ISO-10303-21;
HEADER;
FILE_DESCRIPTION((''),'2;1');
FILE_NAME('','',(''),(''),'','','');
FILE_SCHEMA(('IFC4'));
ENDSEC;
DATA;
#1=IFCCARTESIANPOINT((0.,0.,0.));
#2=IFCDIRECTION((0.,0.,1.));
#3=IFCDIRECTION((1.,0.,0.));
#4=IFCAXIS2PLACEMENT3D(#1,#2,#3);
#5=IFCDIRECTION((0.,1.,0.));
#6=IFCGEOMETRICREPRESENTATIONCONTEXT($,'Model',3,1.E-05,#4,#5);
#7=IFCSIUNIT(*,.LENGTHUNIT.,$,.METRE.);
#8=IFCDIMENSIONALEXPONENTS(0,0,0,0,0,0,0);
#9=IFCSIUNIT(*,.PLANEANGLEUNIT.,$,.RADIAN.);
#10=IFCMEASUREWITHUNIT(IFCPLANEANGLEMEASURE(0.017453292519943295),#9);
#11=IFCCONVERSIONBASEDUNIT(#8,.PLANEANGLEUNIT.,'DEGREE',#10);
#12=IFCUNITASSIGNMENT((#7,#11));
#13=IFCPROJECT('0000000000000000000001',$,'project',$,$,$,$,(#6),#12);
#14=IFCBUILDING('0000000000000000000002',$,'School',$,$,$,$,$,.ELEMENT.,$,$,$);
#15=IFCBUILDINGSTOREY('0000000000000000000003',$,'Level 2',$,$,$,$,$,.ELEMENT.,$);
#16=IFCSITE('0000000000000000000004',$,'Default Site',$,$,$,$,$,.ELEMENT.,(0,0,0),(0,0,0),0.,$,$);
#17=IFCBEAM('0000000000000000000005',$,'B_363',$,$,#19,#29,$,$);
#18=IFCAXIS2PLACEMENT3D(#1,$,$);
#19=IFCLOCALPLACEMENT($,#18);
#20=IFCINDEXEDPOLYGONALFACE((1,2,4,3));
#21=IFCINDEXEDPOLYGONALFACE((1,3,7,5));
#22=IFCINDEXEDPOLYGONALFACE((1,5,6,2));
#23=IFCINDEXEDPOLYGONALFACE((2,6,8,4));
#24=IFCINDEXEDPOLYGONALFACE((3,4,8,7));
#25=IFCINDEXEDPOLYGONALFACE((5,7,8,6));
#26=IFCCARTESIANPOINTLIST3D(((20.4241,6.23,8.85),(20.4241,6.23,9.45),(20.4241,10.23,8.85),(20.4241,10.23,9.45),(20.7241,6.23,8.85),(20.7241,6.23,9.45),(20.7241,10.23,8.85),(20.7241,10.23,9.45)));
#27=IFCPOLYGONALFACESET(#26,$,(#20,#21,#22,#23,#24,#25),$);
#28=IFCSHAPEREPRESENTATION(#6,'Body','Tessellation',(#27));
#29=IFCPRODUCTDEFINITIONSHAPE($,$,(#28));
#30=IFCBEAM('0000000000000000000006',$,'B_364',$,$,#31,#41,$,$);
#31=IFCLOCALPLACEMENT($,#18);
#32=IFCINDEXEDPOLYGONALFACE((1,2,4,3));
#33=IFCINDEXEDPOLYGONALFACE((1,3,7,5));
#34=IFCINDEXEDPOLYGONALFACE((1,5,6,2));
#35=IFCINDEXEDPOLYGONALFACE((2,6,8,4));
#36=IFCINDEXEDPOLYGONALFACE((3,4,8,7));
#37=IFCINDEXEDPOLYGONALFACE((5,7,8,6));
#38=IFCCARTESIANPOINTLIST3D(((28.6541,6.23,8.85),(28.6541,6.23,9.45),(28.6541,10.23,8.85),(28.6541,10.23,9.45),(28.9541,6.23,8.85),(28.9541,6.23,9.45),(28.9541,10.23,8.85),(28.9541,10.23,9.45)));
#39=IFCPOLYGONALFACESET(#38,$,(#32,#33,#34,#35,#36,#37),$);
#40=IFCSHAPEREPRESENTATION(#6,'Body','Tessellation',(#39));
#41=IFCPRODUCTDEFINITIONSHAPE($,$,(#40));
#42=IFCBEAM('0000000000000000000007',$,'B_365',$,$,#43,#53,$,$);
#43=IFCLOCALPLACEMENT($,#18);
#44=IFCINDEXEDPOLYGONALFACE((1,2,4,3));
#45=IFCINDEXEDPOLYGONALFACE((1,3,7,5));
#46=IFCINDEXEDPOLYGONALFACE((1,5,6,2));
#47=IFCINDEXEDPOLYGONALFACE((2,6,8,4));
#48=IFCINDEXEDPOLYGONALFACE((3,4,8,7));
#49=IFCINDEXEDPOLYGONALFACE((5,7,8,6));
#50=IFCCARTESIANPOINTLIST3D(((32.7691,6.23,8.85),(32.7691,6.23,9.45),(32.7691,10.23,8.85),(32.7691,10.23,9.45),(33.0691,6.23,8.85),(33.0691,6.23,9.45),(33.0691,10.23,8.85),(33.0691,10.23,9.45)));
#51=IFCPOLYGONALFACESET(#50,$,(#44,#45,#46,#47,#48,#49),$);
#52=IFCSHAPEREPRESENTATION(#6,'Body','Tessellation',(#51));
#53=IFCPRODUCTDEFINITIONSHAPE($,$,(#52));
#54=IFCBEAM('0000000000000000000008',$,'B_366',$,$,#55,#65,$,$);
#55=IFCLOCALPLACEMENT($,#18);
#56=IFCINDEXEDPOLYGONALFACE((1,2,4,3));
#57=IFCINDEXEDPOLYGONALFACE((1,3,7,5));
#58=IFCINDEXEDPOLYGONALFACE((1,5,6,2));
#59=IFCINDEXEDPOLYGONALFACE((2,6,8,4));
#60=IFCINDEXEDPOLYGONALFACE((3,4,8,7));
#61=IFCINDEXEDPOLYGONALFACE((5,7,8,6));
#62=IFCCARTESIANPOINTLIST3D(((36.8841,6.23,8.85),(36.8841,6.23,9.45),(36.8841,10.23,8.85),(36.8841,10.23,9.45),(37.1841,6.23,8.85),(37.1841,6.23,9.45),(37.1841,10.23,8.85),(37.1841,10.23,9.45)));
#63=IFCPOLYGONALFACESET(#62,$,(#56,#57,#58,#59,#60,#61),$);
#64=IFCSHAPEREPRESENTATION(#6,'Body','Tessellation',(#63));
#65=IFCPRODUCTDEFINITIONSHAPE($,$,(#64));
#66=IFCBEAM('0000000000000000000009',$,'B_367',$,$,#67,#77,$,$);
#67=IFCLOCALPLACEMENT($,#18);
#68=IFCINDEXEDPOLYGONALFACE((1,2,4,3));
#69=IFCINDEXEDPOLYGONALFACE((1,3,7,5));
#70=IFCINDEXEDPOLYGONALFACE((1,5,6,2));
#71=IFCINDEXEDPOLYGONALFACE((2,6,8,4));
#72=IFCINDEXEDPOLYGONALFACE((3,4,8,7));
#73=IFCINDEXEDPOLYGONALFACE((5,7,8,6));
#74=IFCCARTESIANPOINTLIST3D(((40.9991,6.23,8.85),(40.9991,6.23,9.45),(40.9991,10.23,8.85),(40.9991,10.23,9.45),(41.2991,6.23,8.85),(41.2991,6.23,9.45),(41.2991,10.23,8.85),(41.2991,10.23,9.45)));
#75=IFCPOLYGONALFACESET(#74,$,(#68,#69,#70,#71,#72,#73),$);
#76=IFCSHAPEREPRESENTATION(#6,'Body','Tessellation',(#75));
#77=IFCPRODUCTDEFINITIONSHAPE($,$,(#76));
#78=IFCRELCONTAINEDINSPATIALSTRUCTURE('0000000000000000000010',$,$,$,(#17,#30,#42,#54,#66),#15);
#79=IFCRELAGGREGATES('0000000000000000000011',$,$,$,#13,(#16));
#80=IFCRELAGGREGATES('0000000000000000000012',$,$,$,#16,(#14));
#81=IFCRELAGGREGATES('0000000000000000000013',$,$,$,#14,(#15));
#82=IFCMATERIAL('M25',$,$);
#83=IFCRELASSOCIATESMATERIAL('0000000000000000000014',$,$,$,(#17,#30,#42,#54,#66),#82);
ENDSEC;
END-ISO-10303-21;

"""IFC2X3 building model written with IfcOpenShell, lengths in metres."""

from ifc_helpers import new_model, entity, si_unit, converted_unit, direction, frame, frame_2d, origin_with_axes, place, context, project, spatial, rectangle, extrude, material, element, save


model = new_model("IFC2X3")

# Units and contexts
model_context = context("Model", 3, precision=1e-05, world=origin_with_axes(), true_north=direction((0.0, 1.0, 0.0)))
ifc_project = project(units=[si_unit("LENGTHUNIT", "METRE"), converted_unit("PLANEANGLEUNIT", "DEGREE", entity("IfcPlaneAngleMeasure", 0.017453292519943295), si_unit("PLANEANGLEUNIT", "RADIAN"), dimensions=[0, 0, 0, 0, 0, 0, 0])], contexts=[model_context])

# Site, building, storey
site = spatial("IfcSite", under=ifc_project, Name="Default Site", CompositionType="ELEMENT", RefLatitude=(0, 0, 0), RefLongitude=(0, 0, 0), RefElevation=0.0)
building = spatial("IfcBuilding", under=site, Name="School", CompositionType="ELEMENT")
storey = spatial("IfcBuildingStorey", under=building, Name="Level 2", CompositionType="ELEMENT")

# Beams
ifc_material = material(Name="M25")
placement = place(None, origin_with_axes())
element("IfcBeam", 1, at=placement, inside=storey, material=ifc_material, Name="B_363", context=model_context, shape_type="SweptSolid", body=[
    extrude(rectangle(XDim=0.3, YDim=0.6, at=frame_2d((0.0, 0.0), x_axis=(0.0, 1.0, 0.0))), frame((20.5741, 6.23, 9.15), z_axis=(0.0, 1.0, 0.0), x_axis=(0.0, 0.0, -1.0)), (0.0, 0.0, 1.0), 4.0),
])
element("IfcBeam", 2, at=placement, inside=storey, material=ifc_material, Name="B_364", context=model_context, shape_type="SweptSolid", body=[
    extrude(rectangle(XDim=0.3, YDim=0.6, at=frame_2d((0.0, 0.0), x_axis=(0.0, 1.0, 0.0))), frame((28.8041, 6.23, 9.15), z_axis=(0.0, 1.0, 0.0), x_axis=(0.0, 0.0, -1.0)), (0.0, 0.0, 1.0), 4.0),
])
element("IfcBeam", 3, at=placement, inside=storey, material=ifc_material, Name="B_365", context=model_context, shape_type="SweptSolid", body=[
    extrude(rectangle(XDim=0.3, YDim=0.6, at=frame_2d((0.0, 0.0), x_axis=(0.0, 1.0, 0.0))), frame((32.9191, 6.23, 9.15), z_axis=(0.0, 1.0, 0.0), x_axis=(0.0, 0.0, -1.0)), (0.0, 0.0, 1.0), 4.0),
])
element("IfcBeam", 4, at=placement, inside=storey, material=ifc_material, Name="B_366", context=model_context, shape_type="SweptSolid", body=[
    extrude(rectangle(XDim=0.3, YDim=0.6, at=frame_2d((0.0, 0.0), x_axis=(0.0, 1.0, 0.0))), frame((37.0341, 6.23, 9.15), z_axis=(0.0, 1.0, 0.0), x_axis=(0.0, 0.0, -1.0)), (0.0, 0.0, 1.0), 4.0),
])
element("IfcBeam", 5, at=placement, inside=storey, material=ifc_material, Name="B_367", context=model_context, shape_type="SweptSolid", body=[
    extrude(rectangle(XDim=0.3, YDim=0.6, at=frame_2d((0.0, 0.0), x_axis=(0.0, 1.0, 0.0))), frame((41.1491, 6.23, 9.15), z_axis=(0.0, 1.0, 0.0), x_axis=(0.0, 0.0, -1.0)), (0.0, 0.0, 1.0), 4.0),
])

save(model, "model.ifc")
